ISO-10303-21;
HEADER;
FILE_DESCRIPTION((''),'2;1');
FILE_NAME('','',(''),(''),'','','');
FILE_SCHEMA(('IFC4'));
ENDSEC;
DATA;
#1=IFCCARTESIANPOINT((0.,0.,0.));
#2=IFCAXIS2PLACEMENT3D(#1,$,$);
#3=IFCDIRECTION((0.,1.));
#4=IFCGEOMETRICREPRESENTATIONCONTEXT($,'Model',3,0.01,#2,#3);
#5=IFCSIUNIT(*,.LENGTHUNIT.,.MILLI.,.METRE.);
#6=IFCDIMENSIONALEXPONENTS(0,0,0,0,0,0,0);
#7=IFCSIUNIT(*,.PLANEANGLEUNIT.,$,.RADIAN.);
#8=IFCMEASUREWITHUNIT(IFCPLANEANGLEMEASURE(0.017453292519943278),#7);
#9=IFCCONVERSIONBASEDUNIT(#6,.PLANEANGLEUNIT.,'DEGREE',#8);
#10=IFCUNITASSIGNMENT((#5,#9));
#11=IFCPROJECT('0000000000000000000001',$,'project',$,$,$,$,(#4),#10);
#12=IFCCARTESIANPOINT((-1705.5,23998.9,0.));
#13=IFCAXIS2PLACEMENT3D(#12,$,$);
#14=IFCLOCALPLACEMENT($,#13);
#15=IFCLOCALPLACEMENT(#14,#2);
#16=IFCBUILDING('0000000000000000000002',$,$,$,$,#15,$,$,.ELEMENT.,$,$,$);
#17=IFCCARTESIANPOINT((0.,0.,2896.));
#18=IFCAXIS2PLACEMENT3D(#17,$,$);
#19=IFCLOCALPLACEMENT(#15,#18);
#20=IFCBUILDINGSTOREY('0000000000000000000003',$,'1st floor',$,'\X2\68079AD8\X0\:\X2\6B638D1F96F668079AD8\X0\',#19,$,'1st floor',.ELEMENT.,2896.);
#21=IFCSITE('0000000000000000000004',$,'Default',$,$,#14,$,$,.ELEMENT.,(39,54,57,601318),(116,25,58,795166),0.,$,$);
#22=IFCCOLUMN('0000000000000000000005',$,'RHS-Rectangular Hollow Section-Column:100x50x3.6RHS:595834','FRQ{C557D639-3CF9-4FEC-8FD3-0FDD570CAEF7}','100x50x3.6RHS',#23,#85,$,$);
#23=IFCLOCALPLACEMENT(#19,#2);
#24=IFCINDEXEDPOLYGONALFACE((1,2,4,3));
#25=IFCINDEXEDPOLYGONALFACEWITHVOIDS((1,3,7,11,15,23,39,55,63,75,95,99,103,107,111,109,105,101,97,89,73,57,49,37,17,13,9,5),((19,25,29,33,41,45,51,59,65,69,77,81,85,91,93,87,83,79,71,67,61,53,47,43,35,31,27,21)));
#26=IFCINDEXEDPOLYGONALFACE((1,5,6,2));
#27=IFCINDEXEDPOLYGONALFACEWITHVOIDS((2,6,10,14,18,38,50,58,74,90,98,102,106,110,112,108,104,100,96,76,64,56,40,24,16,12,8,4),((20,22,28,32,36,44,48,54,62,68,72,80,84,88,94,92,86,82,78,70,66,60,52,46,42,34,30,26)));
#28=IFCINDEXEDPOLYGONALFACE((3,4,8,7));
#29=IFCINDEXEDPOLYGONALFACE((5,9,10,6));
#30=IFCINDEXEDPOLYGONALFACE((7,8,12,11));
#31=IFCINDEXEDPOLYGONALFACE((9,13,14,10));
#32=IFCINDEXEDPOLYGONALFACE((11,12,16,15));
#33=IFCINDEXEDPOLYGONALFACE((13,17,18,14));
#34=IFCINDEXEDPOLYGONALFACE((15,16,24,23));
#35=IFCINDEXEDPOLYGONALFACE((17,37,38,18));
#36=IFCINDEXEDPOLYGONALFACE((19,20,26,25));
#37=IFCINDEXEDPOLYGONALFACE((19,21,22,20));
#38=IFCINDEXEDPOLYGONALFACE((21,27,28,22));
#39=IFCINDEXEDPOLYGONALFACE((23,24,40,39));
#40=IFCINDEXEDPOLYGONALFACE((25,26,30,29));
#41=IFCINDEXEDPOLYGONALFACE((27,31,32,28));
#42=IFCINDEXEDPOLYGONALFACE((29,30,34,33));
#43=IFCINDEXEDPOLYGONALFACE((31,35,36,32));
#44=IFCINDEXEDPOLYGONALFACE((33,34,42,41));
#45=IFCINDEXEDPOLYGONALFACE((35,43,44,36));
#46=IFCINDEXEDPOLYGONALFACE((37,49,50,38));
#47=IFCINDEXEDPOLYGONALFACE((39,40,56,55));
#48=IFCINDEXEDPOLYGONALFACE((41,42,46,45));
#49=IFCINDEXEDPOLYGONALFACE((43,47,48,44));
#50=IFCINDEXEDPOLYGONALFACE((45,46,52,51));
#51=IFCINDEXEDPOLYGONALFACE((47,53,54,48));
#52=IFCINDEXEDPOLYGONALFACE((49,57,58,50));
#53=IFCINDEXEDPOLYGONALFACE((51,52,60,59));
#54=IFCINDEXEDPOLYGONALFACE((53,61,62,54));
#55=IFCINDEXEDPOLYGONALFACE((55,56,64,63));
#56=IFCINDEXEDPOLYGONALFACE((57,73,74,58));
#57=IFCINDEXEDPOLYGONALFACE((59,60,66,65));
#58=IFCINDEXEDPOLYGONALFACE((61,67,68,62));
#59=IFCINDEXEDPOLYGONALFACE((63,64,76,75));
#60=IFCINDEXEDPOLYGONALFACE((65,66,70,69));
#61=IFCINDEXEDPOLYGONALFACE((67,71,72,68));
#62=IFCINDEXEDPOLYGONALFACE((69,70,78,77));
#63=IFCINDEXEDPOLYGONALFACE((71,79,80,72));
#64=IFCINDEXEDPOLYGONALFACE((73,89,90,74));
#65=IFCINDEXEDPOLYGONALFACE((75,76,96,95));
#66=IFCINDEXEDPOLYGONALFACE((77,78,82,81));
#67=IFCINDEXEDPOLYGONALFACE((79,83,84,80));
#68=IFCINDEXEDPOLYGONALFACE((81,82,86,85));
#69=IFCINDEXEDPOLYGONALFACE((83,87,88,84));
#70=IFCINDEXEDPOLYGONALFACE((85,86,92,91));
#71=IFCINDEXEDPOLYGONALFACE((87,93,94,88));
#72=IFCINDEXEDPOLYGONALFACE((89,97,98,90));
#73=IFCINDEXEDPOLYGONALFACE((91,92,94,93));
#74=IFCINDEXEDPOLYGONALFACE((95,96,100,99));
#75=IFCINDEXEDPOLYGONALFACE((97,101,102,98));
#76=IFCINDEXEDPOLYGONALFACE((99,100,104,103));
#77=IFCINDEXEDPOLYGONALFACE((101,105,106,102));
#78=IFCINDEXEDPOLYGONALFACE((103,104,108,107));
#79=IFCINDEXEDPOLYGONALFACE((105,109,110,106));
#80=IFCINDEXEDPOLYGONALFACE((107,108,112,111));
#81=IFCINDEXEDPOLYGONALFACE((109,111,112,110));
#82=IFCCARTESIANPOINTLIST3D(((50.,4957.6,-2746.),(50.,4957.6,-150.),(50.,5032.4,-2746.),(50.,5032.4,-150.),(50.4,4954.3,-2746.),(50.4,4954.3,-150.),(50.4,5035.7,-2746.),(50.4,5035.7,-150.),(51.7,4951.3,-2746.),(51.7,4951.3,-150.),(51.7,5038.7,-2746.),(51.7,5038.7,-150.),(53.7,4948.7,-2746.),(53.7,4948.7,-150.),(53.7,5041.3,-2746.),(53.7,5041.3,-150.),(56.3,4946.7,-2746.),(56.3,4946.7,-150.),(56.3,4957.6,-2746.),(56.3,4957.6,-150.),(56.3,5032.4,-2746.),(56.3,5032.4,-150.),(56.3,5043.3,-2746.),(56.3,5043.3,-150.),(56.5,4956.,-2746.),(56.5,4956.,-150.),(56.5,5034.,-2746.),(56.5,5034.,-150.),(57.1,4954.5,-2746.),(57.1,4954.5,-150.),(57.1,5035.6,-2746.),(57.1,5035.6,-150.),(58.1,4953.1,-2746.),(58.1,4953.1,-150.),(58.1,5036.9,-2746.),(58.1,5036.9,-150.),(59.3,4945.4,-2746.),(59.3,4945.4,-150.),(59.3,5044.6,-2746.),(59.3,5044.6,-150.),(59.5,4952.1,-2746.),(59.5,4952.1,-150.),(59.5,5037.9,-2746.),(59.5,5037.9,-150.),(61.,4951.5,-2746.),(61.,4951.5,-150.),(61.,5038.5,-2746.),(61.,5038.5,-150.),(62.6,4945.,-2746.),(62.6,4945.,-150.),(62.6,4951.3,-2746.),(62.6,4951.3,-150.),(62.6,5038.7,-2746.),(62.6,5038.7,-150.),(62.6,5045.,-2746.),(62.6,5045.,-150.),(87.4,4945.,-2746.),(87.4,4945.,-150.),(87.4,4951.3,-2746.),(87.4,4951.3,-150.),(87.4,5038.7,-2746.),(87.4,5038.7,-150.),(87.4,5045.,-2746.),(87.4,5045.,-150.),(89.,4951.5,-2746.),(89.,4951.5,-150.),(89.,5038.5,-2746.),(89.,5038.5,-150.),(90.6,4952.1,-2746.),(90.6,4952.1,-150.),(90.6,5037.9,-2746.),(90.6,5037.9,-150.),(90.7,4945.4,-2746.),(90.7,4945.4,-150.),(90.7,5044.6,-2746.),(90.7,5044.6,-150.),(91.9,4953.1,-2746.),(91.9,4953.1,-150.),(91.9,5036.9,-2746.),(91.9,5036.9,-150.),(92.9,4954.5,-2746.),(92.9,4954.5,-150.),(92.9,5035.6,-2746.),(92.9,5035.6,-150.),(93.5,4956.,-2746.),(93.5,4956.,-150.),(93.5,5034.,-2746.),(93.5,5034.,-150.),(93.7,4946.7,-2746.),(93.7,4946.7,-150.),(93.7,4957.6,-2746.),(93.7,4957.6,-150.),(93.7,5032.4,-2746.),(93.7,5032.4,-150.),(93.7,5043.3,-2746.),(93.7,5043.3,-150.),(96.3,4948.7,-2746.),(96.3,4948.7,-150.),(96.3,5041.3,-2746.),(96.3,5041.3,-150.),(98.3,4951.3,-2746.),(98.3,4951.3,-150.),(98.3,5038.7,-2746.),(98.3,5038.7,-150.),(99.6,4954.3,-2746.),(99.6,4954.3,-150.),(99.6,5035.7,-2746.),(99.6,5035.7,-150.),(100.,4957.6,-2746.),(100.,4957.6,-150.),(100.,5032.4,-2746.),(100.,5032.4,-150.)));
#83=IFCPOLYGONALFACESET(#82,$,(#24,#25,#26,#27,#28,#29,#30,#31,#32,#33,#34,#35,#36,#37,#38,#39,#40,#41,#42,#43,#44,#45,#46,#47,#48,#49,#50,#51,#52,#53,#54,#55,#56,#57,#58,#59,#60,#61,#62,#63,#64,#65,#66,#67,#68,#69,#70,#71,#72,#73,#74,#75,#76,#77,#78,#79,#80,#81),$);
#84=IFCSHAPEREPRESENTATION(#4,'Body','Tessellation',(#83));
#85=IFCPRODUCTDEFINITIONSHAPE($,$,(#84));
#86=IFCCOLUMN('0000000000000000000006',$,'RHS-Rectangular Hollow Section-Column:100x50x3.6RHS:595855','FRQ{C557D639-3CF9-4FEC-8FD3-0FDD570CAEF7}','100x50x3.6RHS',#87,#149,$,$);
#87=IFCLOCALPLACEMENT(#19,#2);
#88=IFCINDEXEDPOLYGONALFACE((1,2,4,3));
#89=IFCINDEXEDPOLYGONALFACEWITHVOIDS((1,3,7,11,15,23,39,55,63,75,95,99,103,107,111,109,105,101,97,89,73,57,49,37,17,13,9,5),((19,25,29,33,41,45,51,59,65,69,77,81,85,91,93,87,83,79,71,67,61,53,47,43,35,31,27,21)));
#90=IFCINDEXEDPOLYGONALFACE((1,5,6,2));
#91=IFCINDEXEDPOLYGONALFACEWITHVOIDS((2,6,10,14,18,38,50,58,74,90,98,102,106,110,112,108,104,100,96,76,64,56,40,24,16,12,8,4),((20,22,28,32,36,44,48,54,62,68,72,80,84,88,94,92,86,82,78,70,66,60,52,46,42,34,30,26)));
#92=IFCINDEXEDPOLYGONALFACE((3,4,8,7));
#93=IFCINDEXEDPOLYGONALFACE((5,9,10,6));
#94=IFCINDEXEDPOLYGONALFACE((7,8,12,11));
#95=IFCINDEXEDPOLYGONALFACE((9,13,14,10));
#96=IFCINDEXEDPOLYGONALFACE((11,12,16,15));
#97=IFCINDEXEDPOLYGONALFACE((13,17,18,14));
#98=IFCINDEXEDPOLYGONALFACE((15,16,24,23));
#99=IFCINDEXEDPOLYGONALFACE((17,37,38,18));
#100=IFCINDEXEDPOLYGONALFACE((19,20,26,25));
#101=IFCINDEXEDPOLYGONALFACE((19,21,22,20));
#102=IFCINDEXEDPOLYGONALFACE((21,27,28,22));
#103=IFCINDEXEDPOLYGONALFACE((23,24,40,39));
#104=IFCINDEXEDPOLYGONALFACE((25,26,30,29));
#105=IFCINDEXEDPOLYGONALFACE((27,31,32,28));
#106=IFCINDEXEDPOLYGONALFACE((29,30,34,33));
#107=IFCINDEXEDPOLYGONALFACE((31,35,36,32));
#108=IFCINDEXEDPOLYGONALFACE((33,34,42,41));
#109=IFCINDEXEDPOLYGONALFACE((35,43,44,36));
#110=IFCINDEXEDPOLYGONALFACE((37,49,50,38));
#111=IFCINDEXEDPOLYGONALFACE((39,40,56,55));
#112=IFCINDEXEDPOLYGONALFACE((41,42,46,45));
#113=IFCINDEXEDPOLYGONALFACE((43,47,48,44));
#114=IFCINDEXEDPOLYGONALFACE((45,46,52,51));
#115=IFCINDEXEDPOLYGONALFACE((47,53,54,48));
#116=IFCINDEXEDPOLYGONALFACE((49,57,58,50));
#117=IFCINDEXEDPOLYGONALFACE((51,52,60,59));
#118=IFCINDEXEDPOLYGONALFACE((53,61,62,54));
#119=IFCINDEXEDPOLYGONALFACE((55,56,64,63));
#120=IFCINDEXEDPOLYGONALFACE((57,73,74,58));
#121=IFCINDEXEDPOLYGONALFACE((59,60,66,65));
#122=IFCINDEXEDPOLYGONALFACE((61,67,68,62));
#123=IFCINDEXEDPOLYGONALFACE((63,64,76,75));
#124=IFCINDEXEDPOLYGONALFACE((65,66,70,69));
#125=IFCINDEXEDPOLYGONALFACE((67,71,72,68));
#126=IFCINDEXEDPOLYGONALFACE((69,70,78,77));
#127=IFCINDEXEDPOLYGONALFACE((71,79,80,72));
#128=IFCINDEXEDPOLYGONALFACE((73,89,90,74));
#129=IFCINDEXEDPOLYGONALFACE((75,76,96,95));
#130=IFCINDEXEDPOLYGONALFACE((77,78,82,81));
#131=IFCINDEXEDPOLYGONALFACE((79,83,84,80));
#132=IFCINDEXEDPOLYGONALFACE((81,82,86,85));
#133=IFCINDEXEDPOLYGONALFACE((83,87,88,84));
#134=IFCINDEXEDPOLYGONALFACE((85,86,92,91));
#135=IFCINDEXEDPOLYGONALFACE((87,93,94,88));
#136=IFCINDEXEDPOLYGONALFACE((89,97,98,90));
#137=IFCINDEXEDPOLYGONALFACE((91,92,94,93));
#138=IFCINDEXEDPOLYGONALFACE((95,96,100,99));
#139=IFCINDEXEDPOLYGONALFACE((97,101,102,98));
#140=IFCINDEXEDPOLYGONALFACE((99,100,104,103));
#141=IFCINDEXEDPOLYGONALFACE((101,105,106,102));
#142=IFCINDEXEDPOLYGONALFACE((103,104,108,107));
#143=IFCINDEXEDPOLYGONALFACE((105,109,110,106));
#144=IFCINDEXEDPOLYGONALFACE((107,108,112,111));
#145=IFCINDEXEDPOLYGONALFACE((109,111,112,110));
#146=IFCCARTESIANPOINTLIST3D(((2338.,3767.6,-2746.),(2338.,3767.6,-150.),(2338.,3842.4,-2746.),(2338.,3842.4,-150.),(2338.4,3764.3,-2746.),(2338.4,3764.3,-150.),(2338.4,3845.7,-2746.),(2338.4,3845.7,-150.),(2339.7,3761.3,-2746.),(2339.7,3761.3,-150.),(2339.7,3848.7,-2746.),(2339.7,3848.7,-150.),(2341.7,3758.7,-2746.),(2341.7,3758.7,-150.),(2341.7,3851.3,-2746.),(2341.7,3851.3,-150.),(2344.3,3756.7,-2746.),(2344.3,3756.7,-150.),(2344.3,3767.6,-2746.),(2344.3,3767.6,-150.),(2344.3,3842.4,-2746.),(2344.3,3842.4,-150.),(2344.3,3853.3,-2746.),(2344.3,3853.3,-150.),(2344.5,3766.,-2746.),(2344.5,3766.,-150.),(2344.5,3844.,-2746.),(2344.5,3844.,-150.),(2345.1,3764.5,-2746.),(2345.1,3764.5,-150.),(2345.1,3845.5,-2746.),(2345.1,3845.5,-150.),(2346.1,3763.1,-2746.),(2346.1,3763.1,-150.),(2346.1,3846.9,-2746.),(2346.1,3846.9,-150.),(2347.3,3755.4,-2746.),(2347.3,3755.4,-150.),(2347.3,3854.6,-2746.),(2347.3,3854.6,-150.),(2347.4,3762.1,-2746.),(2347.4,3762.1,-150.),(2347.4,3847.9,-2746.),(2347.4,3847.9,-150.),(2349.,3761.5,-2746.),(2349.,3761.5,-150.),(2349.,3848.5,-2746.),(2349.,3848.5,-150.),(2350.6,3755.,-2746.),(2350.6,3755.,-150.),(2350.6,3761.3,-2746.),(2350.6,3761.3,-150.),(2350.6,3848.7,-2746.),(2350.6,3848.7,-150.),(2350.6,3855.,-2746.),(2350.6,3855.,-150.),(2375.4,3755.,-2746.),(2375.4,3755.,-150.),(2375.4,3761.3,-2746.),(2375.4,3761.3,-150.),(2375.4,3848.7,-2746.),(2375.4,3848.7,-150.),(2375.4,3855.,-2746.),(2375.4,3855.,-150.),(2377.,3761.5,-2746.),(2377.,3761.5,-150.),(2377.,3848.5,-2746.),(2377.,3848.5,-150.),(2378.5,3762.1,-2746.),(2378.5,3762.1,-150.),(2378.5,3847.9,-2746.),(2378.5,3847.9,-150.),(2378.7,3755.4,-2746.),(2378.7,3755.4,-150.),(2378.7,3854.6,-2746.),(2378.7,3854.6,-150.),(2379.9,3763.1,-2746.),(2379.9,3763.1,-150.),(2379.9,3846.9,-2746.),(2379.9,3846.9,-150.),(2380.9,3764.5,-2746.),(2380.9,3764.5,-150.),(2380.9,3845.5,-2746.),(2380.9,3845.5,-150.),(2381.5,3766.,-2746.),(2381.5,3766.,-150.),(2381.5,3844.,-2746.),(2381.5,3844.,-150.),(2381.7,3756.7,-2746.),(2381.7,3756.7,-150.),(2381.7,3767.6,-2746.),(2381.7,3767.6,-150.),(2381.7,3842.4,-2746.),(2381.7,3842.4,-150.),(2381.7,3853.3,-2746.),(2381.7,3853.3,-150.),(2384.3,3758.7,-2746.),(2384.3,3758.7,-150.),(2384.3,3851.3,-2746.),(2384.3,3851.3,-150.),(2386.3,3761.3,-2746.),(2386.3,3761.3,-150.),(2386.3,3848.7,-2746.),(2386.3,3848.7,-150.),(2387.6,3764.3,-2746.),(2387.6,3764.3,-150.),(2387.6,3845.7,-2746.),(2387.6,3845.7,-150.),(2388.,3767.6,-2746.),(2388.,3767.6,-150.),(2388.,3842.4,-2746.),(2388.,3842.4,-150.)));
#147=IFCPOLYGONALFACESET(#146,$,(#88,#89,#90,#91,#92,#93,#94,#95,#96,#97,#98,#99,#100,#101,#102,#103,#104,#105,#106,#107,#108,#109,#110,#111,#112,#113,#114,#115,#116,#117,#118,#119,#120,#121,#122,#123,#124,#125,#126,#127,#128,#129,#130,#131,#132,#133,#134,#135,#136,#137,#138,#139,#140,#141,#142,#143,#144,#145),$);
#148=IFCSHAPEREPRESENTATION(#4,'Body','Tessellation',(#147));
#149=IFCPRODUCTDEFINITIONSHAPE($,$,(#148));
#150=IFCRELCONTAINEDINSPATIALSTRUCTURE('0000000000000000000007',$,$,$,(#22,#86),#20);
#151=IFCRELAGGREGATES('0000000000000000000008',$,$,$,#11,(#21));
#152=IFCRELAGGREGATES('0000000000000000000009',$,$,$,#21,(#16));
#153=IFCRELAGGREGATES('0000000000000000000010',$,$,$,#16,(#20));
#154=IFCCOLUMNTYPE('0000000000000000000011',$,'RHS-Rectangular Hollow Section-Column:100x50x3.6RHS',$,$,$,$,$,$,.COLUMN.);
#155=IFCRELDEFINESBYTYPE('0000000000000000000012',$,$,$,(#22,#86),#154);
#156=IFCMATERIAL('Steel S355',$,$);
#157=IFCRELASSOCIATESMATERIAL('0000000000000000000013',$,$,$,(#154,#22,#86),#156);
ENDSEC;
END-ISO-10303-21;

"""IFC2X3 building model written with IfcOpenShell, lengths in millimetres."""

from ifc_helpers import new_model, entity, si_unit, converted_unit, direction, frame, origin, origin_2d, place, context, project, spatial, hollow_rectangle, extrude, clip, halfspace, material, type_object, element, save


model = new_model("IFC2X3")

# Units and contexts
model_context = context("Model", 3, precision=0.01, world=origin(), true_north=direction((0.0, 1.0)))
ifc_project = project(units=[si_unit("LENGTHUNIT", "METRE", prefix="MILLI"), converted_unit("PLANEANGLEUNIT", "DEGREE", entity("IfcPlaneAngleMeasure", 0.017453292519943278), si_unit("PLANEANGLEUNIT", "RADIAN"), dimensions=[0, 0, 0, 0, 0, 0, 0])], contexts=[model_context])

# Site, building, storey
site_placement = place(None, frame((-1705.5, 23998.9, 0.0)))
site = spatial("IfcSite", under=ifc_project, at=site_placement, Name="Default", CompositionType="ELEMENT", RefLatitude=(39, 54, 57, 601318), RefLongitude=(116, 25, 58, 795166), RefElevation=0.0)
building_placement = place(site_placement, origin())
building = spatial("IfcBuilding", under=site, at=building_placement, CompositionType="ELEMENT")
storey_placement = place(building_placement, frame((0.0, 0.0, 2896.0)))
storey = spatial("IfcBuildingStorey", under=building, at=storey_placement, Name="1st floor", ObjectType="标高:正负零标高", LongName="1st floor", CompositionType="ELEMENT", Elevation=2896.0)

# Shared definitions
ifc_material_1 = material(Name="Steel S355")

# Columns
column_type_1 = type_object("IfcColumnType", Name="RHS-Rectangular Hollow Section-Column:100x50x3.6RHS", PredefinedType="COLUMN", material=ifc_material_1)
column_1_placement = place(storey_placement, frame((75.0, 4995.0, -150.0), z_axis=(0.0, 0.0, 1.0), x_axis=(-1.0, 0.0, 0.0)))
element("IfcColumn", 1, at=column_1_placement, inside=storey, type_object=column_type_1, material=ifc_material_1, Name="RHS-Rectangular Hollow Section-Column:100x50x3.6RHS:595834", Description="FRQ{C557D639-3CF9-4FEC-8FD3-0FDD570CAEF7}", ObjectType="100x50x3.6RHS", context=model_context, shape_type="Clipping", body=[
    clip(extrude(hollow_rectangle(XDim=50.0, YDim=100.0, WallThickness=6.3, InnerFilletRadius=6.3, OuterFilletRadius=12.6, at=origin_2d()), origin(), (0.0, 0.0, -1.0), 2651.9), halfspace(frame((75.0, 4995.0, -2596.0), z_axis=(0.0, 0.0, 1.0), x_axis=(-1.0, 0.0, 0.0)), True)),
])
column_2_placement = place(storey_placement, frame((2363.0, 3805.0, -150.0), z_axis=(0.0, 0.0, 1.0), x_axis=(-1.0, 0.0, 0.0)))
element("IfcColumn", 2, at=column_2_placement, inside=storey, type_object=column_type_1, material=ifc_material_1, Name="RHS-Rectangular Hollow Section-Column:100x50x3.6RHS:595855", Description="FRQ{C557D639-3CF9-4FEC-8FD3-0FDD570CAEF7}", ObjectType="100x50x3.6RHS", context=model_context, shape_type="Clipping", body=[
    clip(extrude(hollow_rectangle(XDim=50.0, YDim=100.0, WallThickness=6.3, InnerFilletRadius=6.3, OuterFilletRadius=12.6, at=origin_2d()), origin(), (0.0, 0.0, -1.0), 2651.9), halfspace(frame((2363.0, 3805.0, -2596.0), z_axis=(0.0, 0.0, 1.0), x_axis=(-1.0, 0.0, 0.0)), True)),
])

save(model, "model.ifc")
